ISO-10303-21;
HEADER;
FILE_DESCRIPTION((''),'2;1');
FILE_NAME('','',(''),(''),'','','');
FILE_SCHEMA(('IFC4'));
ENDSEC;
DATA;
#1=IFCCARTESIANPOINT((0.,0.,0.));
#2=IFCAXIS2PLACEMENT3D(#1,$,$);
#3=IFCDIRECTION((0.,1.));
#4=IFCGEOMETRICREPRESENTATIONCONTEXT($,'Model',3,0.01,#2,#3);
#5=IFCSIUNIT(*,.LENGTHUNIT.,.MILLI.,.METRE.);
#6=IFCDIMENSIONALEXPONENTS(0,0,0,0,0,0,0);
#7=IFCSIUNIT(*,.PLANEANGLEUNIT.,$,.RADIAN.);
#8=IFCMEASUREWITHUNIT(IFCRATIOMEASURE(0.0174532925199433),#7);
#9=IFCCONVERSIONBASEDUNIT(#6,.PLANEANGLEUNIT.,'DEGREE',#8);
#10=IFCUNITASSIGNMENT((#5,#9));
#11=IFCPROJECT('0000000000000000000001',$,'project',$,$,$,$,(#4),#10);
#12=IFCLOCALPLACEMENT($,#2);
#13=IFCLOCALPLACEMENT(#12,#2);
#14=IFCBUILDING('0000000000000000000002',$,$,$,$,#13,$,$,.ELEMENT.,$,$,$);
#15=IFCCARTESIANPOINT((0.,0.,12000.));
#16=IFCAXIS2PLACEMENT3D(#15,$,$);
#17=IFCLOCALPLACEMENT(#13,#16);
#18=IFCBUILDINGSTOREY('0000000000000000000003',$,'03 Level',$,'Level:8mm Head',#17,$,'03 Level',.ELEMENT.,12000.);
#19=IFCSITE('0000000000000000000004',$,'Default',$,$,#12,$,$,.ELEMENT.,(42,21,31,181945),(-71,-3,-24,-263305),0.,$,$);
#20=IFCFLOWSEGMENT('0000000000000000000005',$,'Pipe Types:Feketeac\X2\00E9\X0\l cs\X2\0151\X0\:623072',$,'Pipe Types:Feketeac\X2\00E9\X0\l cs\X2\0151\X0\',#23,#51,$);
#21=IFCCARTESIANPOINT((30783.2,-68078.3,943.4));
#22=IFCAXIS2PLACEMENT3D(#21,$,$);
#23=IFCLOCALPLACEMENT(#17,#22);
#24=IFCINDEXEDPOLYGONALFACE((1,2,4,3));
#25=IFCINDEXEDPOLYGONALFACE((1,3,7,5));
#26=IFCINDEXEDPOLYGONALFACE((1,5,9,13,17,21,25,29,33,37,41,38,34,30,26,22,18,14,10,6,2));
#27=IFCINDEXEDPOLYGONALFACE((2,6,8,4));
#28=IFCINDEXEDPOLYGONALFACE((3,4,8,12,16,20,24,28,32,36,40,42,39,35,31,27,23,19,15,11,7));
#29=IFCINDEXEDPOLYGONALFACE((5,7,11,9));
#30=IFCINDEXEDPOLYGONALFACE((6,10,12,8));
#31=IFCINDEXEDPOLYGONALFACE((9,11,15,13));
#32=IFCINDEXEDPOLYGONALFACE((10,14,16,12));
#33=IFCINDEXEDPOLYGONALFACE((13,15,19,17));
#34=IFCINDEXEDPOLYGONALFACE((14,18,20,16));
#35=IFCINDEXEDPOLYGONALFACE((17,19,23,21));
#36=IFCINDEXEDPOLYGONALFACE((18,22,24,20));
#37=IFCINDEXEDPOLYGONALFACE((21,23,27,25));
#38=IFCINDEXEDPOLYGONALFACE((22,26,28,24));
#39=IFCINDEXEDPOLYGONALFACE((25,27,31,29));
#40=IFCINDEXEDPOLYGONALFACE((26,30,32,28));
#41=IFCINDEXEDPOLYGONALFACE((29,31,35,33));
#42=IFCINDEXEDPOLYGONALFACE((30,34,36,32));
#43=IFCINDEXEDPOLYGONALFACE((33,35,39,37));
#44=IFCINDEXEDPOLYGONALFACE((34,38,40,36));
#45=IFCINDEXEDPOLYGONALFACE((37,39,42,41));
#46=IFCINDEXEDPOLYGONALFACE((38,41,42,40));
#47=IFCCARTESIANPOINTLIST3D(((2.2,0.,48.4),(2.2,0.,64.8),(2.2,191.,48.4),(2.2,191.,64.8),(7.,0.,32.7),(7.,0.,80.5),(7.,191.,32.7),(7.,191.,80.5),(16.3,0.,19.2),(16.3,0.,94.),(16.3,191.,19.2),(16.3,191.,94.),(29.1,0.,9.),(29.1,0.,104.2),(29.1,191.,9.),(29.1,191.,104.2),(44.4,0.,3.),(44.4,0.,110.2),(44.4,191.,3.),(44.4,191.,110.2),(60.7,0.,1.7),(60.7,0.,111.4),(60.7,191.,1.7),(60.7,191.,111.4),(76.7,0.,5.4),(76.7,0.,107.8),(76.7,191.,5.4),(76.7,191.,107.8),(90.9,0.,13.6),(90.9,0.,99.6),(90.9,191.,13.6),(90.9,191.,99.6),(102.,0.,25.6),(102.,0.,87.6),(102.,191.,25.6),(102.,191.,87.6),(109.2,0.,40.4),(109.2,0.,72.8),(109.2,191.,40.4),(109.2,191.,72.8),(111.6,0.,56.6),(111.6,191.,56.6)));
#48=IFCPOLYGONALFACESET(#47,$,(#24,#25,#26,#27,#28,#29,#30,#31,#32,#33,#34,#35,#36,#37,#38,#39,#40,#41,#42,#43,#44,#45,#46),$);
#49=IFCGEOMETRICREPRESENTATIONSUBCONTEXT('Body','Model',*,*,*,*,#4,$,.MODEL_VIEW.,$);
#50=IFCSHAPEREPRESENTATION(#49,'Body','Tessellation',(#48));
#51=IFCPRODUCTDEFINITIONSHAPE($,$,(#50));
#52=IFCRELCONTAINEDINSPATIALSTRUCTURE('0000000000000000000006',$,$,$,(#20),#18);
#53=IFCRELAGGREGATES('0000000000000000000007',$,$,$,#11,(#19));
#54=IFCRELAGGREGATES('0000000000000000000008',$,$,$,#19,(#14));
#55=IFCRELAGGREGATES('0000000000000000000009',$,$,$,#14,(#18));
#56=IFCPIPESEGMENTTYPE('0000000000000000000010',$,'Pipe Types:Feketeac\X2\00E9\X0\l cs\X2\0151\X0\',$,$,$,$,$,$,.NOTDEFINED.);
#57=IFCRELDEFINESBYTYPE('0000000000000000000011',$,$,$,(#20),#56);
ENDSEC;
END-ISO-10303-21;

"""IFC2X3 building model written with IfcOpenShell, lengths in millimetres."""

from ifc_helpers import new_model, entity, si_unit, converted_unit, direction, frame, origin, origin_2d_with_axis, place, context, subcontext, project, spatial, circle, extrude, type_object, element, save


model = new_model("IFC2X3")

# Units and contexts
model_context = context("Model", 3, precision=0.01, world=origin(), true_north=direction((0.0, 1.0)))
body_context = subcontext(model_context, "Body", "Model", "MODEL_VIEW")
ifc_project = project(units=[si_unit("LENGTHUNIT", "METRE", prefix="MILLI"), converted_unit("PLANEANGLEUNIT", "DEGREE", entity("IfcRatioMeasure", 0.0174532925199433), si_unit("PLANEANGLEUNIT", "RADIAN"), dimensions=[0, 0, 0, 0, 0, 0, 0])], contexts=[model_context])

# Site, building, storey
site_placement = place(None, origin())
site = spatial("IfcSite", under=ifc_project, at=site_placement, Name="Default", CompositionType="ELEMENT", RefLatitude=(42, 21, 31, 181945), RefLongitude=(-71, -3, -24, -263305), RefElevation=0.0)
building_placement = place(site_placement, origin())
building = spatial("IfcBuilding", under=site, at=building_placement, CompositionType="ELEMENT")
storey_placement = place(building_placement, frame((0.0, 0.0, 12000.0)))
storey = spatial("IfcBuildingStorey", under=building, at=storey_placement, Name="03 Level", ObjectType="Level:8mm Head", LongName="03 Level", CompositionType="ELEMENT", Elevation=12000.0)

# Flow segment
pipe_segment_type = type_object("IfcPipeSegmentType", Name="Pipe Types:Feketeacél cső", PredefinedType="NOTDEFINED")
flow_segment_placement = place(storey_placement, frame((30783.2, -68078.3, 943.4)))
element("IfcFlowSegment", 1, at=flow_segment_placement, inside=storey, type_object=pipe_segment_type, Name="Pipe Types:Feketeacél cső:623072", ObjectType="Pipe Types:Feketeacél cső", context=body_context, shape_type="SweptSolid", body=[
    extrude(circle(Radius=55.0, at=origin_2d_with_axis()), frame((56.6, 0.0, 56.6), z_axis=(0.0, 1.0, 0.0), x_axis=(1.0, 0.0, 0.0)), (0.0, 0.0, 1.0), 191.0),
])

save(model, "model.ifc")
